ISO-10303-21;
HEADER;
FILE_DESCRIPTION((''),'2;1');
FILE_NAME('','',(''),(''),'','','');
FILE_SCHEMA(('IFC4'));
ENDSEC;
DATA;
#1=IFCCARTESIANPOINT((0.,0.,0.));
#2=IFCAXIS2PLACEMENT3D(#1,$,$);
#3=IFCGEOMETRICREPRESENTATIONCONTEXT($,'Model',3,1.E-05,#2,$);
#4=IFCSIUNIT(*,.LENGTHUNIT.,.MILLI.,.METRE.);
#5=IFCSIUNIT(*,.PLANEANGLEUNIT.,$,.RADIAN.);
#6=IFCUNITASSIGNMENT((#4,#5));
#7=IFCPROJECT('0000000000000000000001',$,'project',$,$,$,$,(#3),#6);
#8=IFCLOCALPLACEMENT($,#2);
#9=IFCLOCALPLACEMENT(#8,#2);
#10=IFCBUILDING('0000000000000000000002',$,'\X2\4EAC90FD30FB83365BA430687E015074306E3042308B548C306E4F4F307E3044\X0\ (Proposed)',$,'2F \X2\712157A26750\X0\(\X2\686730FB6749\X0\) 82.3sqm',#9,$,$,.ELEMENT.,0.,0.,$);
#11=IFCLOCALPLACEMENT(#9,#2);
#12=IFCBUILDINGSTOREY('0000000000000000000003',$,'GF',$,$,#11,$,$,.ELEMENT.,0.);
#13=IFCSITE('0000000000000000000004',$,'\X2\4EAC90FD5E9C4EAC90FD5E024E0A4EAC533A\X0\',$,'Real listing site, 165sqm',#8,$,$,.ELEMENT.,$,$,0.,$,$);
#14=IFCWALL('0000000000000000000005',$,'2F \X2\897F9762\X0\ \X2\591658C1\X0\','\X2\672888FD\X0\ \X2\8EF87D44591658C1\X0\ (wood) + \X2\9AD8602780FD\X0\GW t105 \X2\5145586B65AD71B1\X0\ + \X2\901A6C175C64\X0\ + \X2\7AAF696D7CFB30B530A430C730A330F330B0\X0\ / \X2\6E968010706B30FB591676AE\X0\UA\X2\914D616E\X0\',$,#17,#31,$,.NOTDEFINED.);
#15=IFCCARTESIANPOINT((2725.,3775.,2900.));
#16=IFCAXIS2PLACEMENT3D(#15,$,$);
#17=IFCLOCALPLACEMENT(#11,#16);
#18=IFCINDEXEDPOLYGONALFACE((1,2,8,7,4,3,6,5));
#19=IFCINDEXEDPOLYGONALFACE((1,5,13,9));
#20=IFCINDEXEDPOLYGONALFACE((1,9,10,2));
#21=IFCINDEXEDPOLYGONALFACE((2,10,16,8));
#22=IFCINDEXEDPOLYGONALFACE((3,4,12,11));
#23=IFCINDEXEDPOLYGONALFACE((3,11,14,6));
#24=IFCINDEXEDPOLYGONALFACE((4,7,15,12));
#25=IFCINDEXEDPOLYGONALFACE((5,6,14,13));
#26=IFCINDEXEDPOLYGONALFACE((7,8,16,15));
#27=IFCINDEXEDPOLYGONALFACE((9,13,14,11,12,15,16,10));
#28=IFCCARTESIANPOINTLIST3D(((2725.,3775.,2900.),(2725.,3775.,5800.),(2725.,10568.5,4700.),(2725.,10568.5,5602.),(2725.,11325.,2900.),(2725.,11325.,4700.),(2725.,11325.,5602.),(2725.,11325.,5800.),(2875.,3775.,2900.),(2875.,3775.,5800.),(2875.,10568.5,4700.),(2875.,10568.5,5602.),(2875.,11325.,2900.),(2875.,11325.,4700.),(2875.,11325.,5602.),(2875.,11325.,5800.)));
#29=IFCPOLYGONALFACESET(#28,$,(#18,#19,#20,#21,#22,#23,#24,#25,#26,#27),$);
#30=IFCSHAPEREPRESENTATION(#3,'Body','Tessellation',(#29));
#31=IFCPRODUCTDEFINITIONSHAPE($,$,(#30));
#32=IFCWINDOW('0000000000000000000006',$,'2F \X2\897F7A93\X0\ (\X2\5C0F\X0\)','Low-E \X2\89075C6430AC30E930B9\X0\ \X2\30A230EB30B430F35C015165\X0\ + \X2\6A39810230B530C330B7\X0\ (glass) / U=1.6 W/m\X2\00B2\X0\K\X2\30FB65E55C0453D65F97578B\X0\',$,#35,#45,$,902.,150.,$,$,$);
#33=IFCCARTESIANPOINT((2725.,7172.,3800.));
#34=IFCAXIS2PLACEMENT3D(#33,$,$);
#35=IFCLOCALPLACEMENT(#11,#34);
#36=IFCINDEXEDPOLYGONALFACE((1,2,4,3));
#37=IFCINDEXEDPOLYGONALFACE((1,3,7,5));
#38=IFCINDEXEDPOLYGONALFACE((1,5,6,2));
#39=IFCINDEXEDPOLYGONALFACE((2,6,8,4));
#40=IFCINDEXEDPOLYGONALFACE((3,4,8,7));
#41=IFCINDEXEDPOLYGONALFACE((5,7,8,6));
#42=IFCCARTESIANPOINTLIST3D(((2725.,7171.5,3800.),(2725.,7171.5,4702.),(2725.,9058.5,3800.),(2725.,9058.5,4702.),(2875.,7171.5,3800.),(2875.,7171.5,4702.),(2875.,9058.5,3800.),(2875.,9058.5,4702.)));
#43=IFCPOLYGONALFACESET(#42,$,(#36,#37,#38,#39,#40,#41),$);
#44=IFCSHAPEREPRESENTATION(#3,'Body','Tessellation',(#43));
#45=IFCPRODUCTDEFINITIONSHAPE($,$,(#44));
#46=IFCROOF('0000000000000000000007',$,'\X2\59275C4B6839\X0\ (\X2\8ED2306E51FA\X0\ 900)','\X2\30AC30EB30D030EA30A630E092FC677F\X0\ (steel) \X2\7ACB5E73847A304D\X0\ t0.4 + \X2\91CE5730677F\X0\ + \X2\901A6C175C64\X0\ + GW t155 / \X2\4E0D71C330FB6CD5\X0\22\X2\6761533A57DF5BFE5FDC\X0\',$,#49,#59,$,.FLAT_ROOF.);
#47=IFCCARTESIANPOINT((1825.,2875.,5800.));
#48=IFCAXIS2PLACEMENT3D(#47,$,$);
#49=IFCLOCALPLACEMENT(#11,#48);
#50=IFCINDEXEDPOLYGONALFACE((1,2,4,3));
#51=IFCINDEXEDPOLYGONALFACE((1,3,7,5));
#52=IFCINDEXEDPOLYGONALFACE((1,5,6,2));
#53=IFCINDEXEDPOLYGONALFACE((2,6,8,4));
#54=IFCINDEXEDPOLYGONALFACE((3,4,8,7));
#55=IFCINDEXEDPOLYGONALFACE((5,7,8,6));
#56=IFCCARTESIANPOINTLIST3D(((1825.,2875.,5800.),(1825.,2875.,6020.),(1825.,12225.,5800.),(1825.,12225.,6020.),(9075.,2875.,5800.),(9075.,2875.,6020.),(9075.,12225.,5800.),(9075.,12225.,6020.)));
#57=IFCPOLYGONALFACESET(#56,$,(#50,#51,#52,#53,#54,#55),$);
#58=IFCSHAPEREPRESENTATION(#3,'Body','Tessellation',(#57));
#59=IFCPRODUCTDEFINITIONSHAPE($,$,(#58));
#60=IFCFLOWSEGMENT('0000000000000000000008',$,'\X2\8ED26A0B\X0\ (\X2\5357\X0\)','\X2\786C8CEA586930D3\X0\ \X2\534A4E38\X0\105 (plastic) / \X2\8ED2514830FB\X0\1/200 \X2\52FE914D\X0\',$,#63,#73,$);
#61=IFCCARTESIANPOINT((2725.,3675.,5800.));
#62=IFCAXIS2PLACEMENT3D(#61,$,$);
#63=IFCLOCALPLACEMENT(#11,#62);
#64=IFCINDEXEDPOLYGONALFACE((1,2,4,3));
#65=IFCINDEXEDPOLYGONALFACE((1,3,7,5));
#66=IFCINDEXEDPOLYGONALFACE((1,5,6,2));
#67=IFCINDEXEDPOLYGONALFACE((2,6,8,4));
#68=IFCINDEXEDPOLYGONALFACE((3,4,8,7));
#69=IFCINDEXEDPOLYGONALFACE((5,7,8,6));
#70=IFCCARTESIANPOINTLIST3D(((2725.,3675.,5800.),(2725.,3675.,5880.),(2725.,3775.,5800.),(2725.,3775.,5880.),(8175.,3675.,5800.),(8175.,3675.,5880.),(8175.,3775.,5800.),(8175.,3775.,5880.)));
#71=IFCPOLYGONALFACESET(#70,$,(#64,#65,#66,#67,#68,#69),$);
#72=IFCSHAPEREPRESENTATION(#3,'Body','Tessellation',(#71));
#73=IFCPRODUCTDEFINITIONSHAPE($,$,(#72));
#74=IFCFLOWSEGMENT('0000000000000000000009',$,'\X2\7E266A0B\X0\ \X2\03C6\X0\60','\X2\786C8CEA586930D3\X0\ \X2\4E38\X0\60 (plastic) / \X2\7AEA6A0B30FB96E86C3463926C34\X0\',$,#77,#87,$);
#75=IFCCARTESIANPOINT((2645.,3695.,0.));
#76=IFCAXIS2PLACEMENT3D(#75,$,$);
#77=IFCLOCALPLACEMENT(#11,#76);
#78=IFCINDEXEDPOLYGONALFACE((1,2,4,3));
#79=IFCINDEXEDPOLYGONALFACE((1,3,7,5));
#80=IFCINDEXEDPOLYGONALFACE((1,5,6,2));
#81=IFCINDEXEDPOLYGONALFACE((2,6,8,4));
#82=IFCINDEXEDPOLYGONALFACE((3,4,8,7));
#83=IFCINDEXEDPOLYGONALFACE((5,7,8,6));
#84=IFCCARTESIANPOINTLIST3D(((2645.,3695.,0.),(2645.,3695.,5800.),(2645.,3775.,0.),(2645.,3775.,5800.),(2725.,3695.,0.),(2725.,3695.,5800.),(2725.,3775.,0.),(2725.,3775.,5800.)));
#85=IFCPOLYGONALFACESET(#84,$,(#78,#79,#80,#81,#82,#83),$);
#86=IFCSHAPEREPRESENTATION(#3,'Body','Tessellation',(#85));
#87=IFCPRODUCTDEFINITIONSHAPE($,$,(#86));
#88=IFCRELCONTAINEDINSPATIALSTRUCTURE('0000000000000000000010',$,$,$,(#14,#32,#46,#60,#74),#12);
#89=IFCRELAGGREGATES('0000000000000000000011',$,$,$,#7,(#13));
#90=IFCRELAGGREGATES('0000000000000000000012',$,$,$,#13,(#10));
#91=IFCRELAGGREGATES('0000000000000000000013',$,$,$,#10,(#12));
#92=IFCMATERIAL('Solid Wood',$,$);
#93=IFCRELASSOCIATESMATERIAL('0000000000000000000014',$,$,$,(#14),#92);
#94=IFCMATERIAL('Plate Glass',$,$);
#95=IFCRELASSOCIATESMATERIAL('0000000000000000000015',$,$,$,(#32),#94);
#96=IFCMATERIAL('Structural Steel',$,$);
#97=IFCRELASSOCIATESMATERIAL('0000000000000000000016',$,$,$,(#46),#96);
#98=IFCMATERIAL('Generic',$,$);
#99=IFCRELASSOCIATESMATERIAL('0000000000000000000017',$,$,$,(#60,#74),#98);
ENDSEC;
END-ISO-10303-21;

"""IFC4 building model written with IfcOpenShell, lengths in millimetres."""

from ifc_helpers import new_model, si_unit, frame, frame_2d, origin, place, context, project, spatial, rectangle, extrude, material, element, fill, save


model = new_model("IFC4")

# Units and contexts
model_context = context("Model", 3, precision=1e-05, world=origin())
ifc_project = project(units=[si_unit("LENGTHUNIT", "METRE", prefix="MILLI"), si_unit("PLANEANGLEUNIT", "RADIAN")], contexts=[model_context])

# Site, building, storey
site_placement = place(None, origin())
site = spatial("IfcSite", under=ifc_project, at=site_placement, Name="京都府京都市上京区", ObjectType="Real listing site, 165sqm", CompositionType="ELEMENT", RefElevation=0.0)
building_placement = place(site_placement, origin())
building = spatial("IfcBuilding", under=site, at=building_placement, Name="京都・茶室と縁側のある和の住まい (Proposed)", ObjectType="2F 無垢材(桧・杉) 82.3sqm", CompositionType="ELEMENT", ElevationOfRefHeight=0.0, ElevationOfTerrain=0.0)
storey_placement = place(building_placement, origin())
storey = spatial("IfcBuildingStorey", under=building, at=storey_placement, Name="GF", CompositionType="ELEMENT", Elevation=0.0)

# Shared definitions
ifc_material_1 = material(Name="Solid Wood")

# Shared definitions
ifc_material_2 = material(Name="Plate Glass")

# Wall, opening, window
wall_1_placement = place(storey_placement, frame((2725.0, 3775.0, 2900.0)))
wall_1 = element("IfcWall", 1, at=wall_1_placement, inside=storey, material=ifc_material_1, Name="2F 西面 外壁", Description="木製 軸組外壁 (wood) + 高性能GW t105 充填断熱 + 通気層 + 窯業系サイディング / 準耐火・外皮UA配慮", PredefinedType="NOTDEFINED", context=model_context, shape_type="SweptSolid", body=[
    extrude(rectangle(XDim=150.0, YDim=7550.0, at=frame_2d((75.0, 3775.0))), frame((2725.0, 3775.0, 2900.0)), (0.0, 0.0, 1.0), 2900.0),
])
opening_1_placement = place(storey_placement, frame((2725.0, 7172.0, 3800.0)))
opening_1 = element("IfcOpeningElement", 2, at=opening_1_placement, cuts=wall_1, PredefinedType="NOTDEFINED", context=model_context, shape_type="SweptSolid", body=[
    extrude(rectangle(XDim=150.0, YDim=1887.0, at=frame_2d((75.0, 943.0))), frame((2725.0, 7172.0, 3800.0)), (0.0, 0.0, 1.0), 902.0),
])
window_1_placement = place(storey_placement, frame((2725.0, 7172.0, 3800.0)))
window_1 = element("IfcWindow", 3, at=window_1_placement, inside=storey, material=ifc_material_2, Name="2F 西窓 (小)", Description="Low-E 複層ガラス アルゴン封入 + 樹脂サッシ (glass) / U=1.6 W/m²K・日射取得型", OverallHeight=902.0, OverallWidth=150.0, context=model_context, shape_type="SweptSolid", body=[
    extrude(rectangle(XDim=150.0, YDim=1887.0, at=frame_2d((75.0, 943.0))), frame((2725.0, 7172.0, 3800.0)), (0.0, 0.0, 1.0), 902.0),
])
fill(opening_1, window_1)

# Roof
ifc_material_3 = material(Name="Structural Steel")
roof_placement = place(storey_placement, frame((1825.0, 2875.0, 5800.0)))
element("IfcRoof", 4, at=roof_placement, inside=storey, material=ifc_material_3, Name="大屋根 (軒の出 900)", Description="ガルバリウム鋼板 (steel) 立平葺き t0.4 + 野地板 + 通気層 + GW t155 / 不燃・法22条区域対応", PredefinedType="FLAT_ROOF", context=model_context, shape_type="SweptSolid", body=[
    extrude(rectangle(XDim=7250.0, YDim=9350.0, at=frame_2d((3625.0, 4675.0))), frame((1825.0, 2875.0, 5800.0)), (0.0, 0.0, 1.0), 220.0),
])

# Flow segments
ifc_material_4 = material(Name="Generic")
flow_segment_1_placement = place(storey_placement, frame((2725.0, 3675.0, 5800.0)))
element("IfcFlowSegment", 5, at=flow_segment_1_placement, inside=storey, material=ifc_material_4, Name="軒樋 (南)", Description="硬質塩ビ 半丸105 (plastic) / 軒先・1/200 勾配", context=model_context, shape_type="SweptSolid", body=[
    extrude(rectangle(XDim=5450.0, YDim=100.0, at=frame_2d((2725.0, 50.0))), frame((2725.0, 3675.0, 5800.0)), (0.0, 0.0, 1.0), 80.0),
])
flow_segment_2_placement = place(storey_placement, frame((2645.0, 3695.0, 0.0)))
element("IfcFlowSegment", 6, at=flow_segment_2_placement, inside=storey, material=ifc_material_4, Name="縦樋 φ60", Description="硬質塩ビ 丸60 (plastic) / 竪樋・雨水排水", context=model_context, shape_type="SweptSolid", body=[
    extrude(rectangle(XDim=80.0, YDim=80.0, at=frame_2d((40.0, 40.0))), frame((2645.0, 3695.0, 0.0)), (0.0, 0.0, 1.0), 5800.0),
])

save(model, "model.ifc")
